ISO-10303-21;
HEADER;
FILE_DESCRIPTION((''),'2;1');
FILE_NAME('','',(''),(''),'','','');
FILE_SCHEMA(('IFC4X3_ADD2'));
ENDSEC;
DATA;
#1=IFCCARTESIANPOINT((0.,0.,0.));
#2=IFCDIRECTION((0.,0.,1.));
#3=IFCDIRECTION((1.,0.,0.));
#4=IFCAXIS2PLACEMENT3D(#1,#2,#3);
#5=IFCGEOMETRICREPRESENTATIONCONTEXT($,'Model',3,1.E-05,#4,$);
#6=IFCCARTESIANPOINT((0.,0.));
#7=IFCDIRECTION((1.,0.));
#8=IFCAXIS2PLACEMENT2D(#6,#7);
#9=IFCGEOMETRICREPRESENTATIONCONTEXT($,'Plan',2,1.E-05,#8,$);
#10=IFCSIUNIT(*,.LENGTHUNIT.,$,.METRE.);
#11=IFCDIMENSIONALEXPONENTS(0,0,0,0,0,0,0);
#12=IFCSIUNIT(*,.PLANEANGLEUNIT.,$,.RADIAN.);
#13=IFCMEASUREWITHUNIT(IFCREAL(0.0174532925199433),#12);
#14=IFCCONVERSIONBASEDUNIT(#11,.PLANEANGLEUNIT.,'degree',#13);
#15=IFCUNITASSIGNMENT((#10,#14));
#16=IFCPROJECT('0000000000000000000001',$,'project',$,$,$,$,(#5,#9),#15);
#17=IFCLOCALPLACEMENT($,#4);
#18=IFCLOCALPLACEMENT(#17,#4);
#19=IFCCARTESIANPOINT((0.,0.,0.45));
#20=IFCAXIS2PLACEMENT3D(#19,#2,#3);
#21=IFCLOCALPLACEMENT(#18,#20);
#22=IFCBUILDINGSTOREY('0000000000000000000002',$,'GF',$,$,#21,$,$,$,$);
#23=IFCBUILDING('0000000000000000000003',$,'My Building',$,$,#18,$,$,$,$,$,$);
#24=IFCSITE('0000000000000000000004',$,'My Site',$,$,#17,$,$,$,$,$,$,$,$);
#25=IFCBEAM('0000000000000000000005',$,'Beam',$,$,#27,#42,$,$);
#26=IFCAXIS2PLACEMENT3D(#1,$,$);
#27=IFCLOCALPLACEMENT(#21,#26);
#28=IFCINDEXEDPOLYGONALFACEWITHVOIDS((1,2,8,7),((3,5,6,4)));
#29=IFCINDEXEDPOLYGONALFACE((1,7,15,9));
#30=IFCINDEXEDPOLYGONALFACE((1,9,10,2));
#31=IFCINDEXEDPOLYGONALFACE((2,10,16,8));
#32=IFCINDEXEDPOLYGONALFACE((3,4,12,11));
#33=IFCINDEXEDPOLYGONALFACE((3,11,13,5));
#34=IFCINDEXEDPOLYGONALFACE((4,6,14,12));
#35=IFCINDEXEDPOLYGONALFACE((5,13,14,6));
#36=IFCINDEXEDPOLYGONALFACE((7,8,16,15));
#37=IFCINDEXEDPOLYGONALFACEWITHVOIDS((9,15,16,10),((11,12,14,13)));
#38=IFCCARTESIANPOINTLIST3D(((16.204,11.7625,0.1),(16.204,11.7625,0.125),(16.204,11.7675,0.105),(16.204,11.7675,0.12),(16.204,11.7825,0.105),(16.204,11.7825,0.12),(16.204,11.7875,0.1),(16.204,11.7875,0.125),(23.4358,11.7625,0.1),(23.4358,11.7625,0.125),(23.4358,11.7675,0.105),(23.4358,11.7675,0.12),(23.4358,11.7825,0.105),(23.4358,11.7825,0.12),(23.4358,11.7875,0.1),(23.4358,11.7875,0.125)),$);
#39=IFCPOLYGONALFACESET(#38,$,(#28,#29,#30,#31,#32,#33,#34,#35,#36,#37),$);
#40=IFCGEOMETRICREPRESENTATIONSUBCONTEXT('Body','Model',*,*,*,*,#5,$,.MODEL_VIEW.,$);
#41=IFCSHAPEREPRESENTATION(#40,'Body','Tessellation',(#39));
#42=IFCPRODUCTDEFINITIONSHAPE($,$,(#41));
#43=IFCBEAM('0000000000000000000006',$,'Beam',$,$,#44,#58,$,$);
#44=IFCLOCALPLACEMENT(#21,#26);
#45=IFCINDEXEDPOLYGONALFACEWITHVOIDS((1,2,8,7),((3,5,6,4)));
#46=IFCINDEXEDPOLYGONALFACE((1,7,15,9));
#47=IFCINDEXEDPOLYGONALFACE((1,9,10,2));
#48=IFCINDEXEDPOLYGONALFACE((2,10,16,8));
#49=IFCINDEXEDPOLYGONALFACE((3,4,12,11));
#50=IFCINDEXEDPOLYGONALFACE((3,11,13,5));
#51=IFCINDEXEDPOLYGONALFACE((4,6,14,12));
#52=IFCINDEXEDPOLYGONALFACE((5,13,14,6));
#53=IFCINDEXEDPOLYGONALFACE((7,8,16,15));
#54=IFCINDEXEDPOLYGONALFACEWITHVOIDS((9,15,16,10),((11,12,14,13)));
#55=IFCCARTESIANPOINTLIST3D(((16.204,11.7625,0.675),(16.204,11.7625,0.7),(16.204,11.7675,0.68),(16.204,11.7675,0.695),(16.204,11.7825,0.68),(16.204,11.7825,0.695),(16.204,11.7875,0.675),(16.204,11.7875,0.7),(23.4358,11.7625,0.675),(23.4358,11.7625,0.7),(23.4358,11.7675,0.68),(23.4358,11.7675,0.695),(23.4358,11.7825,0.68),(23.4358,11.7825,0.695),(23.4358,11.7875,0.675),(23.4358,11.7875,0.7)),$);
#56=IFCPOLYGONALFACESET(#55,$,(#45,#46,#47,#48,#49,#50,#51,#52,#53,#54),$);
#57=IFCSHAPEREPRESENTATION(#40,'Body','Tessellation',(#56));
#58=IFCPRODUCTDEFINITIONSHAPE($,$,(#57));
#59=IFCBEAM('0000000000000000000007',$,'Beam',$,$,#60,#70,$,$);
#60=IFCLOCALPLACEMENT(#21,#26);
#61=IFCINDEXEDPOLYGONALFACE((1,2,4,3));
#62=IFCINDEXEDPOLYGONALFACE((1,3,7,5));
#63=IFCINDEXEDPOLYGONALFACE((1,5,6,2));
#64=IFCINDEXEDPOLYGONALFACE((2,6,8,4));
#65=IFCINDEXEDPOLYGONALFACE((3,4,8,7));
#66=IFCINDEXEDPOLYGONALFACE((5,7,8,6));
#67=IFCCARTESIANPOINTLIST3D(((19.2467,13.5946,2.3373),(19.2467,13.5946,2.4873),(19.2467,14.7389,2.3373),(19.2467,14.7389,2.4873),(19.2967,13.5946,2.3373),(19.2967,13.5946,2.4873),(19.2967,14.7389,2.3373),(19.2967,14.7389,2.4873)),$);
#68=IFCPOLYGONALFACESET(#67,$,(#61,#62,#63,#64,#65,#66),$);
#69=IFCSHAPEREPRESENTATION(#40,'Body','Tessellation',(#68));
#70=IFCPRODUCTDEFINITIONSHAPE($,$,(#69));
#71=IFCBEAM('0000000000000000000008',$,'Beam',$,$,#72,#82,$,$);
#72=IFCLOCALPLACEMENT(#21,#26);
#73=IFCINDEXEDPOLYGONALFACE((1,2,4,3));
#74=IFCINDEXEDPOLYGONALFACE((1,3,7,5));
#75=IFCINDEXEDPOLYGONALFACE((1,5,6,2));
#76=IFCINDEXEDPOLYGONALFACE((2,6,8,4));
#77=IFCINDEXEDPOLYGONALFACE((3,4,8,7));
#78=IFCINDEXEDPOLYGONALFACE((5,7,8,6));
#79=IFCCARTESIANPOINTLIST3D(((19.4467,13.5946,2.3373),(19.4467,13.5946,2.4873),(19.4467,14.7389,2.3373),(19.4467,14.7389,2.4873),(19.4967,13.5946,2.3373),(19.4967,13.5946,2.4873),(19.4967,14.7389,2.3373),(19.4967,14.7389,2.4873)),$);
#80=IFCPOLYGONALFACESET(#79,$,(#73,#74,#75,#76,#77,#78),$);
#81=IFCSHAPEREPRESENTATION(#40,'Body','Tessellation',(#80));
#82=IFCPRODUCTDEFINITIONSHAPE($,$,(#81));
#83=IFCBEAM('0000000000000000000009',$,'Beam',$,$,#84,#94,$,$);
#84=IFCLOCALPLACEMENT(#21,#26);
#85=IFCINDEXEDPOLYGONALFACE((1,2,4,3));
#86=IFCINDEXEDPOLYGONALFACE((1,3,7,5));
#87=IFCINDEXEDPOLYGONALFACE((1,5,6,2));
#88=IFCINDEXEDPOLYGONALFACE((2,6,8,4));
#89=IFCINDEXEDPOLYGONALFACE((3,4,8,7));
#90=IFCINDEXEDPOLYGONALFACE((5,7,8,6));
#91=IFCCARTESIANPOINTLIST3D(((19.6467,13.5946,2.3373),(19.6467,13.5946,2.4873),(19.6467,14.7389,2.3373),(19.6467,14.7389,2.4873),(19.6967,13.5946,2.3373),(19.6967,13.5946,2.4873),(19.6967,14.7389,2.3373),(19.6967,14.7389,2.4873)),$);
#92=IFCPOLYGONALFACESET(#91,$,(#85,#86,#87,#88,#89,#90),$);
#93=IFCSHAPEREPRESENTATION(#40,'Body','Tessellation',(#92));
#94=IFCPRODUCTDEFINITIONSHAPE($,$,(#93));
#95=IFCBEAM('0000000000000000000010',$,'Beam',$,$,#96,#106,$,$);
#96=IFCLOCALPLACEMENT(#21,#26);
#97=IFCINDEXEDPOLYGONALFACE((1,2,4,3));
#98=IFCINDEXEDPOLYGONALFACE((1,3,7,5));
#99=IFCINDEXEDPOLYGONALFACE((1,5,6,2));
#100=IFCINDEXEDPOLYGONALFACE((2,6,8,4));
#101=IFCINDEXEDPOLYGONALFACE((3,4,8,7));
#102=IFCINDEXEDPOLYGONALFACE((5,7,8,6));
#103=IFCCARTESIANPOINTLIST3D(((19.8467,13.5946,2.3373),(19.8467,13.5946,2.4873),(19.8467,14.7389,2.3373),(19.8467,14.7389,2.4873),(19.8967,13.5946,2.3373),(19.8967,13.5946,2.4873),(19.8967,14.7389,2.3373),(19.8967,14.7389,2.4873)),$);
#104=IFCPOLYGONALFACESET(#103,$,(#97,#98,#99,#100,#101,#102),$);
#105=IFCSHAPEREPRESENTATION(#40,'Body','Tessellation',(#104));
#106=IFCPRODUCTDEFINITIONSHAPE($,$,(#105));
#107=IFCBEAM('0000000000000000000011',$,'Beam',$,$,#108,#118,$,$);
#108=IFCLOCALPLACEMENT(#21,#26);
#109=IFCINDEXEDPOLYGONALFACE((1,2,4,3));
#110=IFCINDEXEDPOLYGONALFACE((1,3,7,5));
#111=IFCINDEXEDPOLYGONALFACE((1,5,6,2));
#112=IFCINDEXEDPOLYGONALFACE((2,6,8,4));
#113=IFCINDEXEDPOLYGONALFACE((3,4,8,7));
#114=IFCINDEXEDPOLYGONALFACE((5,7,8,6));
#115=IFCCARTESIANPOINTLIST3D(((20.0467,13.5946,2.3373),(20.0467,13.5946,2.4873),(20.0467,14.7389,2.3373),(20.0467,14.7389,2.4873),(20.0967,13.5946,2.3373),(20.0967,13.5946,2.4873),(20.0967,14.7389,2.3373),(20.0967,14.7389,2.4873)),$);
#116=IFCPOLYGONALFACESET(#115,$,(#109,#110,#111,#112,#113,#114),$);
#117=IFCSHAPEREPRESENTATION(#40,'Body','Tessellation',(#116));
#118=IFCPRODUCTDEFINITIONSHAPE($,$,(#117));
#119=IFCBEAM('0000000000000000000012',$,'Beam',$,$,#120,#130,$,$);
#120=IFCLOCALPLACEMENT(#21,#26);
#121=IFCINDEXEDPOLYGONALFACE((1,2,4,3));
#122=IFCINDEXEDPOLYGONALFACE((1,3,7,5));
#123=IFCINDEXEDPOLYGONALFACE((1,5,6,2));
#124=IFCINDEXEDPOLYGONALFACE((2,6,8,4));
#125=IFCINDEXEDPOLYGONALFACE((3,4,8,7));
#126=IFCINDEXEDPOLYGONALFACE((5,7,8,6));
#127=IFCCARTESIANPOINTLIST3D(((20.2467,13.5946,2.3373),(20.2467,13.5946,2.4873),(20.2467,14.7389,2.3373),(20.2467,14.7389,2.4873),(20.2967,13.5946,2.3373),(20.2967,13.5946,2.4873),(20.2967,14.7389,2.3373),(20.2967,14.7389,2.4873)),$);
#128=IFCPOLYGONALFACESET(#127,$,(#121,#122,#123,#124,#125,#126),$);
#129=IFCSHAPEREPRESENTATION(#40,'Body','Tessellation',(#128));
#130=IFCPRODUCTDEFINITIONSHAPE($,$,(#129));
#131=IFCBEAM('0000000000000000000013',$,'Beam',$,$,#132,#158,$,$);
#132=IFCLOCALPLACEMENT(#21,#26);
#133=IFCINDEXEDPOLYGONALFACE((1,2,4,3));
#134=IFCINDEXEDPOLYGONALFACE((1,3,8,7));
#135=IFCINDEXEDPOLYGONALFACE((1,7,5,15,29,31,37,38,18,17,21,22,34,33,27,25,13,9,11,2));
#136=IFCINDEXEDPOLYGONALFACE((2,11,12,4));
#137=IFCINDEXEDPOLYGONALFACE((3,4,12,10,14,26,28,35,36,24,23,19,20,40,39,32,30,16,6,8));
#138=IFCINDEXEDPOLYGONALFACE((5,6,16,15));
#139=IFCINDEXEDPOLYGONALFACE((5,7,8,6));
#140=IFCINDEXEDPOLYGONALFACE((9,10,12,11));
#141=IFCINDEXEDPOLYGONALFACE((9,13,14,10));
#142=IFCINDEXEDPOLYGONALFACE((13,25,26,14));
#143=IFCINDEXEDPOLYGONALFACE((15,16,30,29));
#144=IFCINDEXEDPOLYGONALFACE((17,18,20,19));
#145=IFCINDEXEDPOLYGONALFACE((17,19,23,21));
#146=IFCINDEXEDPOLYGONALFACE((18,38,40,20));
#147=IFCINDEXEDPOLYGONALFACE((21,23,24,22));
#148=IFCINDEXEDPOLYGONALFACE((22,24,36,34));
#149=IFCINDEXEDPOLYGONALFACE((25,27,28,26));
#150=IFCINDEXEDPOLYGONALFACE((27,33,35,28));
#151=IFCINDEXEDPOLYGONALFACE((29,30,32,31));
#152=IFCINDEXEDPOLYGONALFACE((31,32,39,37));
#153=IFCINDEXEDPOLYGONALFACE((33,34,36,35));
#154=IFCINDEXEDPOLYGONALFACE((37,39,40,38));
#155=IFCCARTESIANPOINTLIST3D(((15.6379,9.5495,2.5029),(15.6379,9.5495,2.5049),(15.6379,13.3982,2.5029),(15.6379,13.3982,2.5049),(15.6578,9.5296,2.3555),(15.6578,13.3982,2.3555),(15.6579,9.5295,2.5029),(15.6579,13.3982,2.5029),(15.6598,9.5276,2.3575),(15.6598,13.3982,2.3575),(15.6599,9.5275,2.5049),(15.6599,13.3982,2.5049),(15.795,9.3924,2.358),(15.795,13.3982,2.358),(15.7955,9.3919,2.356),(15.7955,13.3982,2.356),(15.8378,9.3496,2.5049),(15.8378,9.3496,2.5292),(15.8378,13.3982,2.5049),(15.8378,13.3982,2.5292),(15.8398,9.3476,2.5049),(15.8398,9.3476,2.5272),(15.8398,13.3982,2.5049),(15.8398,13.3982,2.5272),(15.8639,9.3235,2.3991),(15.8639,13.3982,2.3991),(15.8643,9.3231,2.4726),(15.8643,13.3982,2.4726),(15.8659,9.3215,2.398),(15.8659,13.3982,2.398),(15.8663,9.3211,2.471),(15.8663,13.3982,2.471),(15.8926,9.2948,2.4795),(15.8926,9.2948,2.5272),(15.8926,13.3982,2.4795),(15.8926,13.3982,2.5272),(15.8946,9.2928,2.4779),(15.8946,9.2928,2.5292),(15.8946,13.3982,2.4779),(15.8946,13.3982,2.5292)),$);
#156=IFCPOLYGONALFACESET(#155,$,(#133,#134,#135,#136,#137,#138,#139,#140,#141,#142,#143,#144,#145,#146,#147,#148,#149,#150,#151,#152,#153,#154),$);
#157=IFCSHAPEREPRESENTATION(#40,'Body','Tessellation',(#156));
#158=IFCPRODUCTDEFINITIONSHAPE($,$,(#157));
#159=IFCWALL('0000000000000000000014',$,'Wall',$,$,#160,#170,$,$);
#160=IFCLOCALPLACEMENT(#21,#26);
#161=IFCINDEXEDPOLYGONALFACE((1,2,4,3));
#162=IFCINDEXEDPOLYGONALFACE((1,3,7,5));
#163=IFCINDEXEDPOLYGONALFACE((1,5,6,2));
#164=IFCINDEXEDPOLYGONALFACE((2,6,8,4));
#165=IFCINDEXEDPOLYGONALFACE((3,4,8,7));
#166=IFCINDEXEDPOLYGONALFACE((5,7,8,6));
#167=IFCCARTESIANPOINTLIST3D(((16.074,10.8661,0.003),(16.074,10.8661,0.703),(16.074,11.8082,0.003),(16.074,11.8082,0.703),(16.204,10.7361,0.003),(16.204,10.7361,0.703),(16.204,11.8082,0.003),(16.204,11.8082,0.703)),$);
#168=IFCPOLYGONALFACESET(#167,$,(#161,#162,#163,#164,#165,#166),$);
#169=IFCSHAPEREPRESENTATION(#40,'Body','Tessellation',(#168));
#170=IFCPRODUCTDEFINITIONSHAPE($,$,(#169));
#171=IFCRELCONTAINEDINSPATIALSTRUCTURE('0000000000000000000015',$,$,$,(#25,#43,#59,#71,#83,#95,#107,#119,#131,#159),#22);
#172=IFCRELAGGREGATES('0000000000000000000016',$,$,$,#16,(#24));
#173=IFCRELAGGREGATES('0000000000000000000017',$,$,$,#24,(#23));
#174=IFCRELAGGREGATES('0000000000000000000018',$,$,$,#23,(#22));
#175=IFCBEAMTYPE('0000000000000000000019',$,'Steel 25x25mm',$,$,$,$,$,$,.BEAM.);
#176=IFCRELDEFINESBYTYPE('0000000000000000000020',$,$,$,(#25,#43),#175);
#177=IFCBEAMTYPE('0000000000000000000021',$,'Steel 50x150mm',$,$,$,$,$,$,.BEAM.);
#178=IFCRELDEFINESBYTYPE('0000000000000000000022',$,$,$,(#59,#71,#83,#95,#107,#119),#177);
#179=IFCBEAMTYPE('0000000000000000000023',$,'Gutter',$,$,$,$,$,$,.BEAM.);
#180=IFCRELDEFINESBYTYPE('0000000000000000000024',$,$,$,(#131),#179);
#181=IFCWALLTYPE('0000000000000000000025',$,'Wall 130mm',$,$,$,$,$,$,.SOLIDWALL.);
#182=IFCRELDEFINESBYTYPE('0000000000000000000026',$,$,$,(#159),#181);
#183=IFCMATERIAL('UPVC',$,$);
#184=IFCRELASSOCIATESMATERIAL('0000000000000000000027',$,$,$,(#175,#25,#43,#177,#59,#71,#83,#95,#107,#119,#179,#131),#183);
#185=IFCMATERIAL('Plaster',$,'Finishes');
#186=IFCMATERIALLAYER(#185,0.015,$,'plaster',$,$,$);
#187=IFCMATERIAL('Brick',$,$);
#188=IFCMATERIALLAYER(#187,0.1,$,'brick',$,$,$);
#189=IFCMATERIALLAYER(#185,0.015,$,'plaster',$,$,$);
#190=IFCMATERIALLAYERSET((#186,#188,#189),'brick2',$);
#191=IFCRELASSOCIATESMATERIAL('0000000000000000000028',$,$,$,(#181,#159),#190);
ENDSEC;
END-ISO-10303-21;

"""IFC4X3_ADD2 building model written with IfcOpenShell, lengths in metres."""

from ifc_helpers import new_model, entity, si_unit, converted_unit, frame, origin_with_axes, origin_2d_with_axis, place, context, subcontext, project, spatial, line, indexed_curve, rectangle, hollow_rectangle, outline, extrude, clip, halfspace, material, layer, layer_set, layer_usage, material_profile, profile_set, profile_usage, type_object, element, save


model = new_model("IFC4X3_ADD2")

# Units and contexts
model_context = context("Model", 3, precision=1e-05, world=origin_with_axes())
plan_context = context("Plan", 2, precision=1e-05, world=origin_2d_with_axis())
body_context = subcontext(model_context, "Body", "Model", "MODEL_VIEW")
ifc_project = project(units=[si_unit("LENGTHUNIT", "METRE"), converted_unit("PLANEANGLEUNIT", "degree", entity("IfcReal", 0.0174532925199433), si_unit("PLANEANGLEUNIT", "RADIAN"), dimensions=[0, 0, 0, 0, 0, 0, 0])], contexts=[model_context, plan_context])

# Site, building, storey
site_placement = place(None, origin_with_axes())
site = spatial("IfcSite", under=ifc_project, at=site_placement, Name="My Site")
building_placement = place(site_placement, origin_with_axes())
building = spatial("IfcBuilding", under=site, at=building_placement, Name="My Building")
storey_placement = place(building_placement, frame((0.0, 0.0, 0.45), z_axis=(0.0, 0.0, 1.0), x_axis=(1.0, 0.0, 0.0)))
storey = spatial("IfcBuildingStorey", under=building, at=storey_placement, Name="GF")

# Shared definitions
ifc_material_1 = material(Name="UPVC")

# Beams
ifc_material_profile_1 = material_profile(ifc_material_1, hollow_rectangle(XDim=0.025, YDim=0.025, WallThickness=0.005))
ifc_profile_set_1 = profile_set([ifc_material_profile_1])
ifc_profile_usage_1 = profile_usage(ifc_profile_set_1)
beam_type_1 = type_object("IfcBeamType", Name="Steel 25x25mm", PredefinedType="BEAM", material=ifc_profile_set_1)
beam_1_placement = place(storey_placement, frame((16.204, 11.775, 0.1125), z_axis=(1.0, 0.0, 0.0), x_axis=(0.0, 1.0, 0.0)))
element("IfcBeam", 1, at=beam_1_placement, inside=storey, type_object=beam_type_1, material=ifc_profile_usage_1, Name="Beam", context=body_context, shape_type="SweptSolid", body=[
    extrude(hollow_rectangle(XDim=0.025, YDim=0.025, WallThickness=0.005), origin_with_axes(), (0.0, 0.0, 1.0), 7.2317),
])
ifc_profile_usage_2 = profile_usage(ifc_profile_set_1)
beam_2_placement = place(storey_placement, frame((16.204, 11.775, 0.6875), z_axis=(1.0, 0.0, 0.0), x_axis=(0.0, 1.0, 0.0)))
element("IfcBeam", 2, at=beam_2_placement, inside=storey, type_object=beam_type_1, material=ifc_profile_usage_2, Name="Beam", context=body_context, shape_type="SweptSolid", body=[
    extrude(hollow_rectangle(XDim=0.025, YDim=0.025, WallThickness=0.005), origin_with_axes(), (0.0, 0.0, 1.0), 7.2317),
])
ifc_material_profile_2 = material_profile(ifc_material_1, rectangle(XDim=0.05, YDim=0.15))
ifc_profile_set_2 = profile_set([ifc_material_profile_2])
ifc_profile_usage_3 = profile_usage(ifc_profile_set_2)
beam_type_2 = type_object("IfcBeamType", Name="Steel 50x150mm", PredefinedType="BEAM", material=ifc_profile_set_2)
beam_3_placement = place(storey_placement, frame((19.2717, 14.7389, 2.4123), z_axis=(0.0, -1.0, 0.0), x_axis=(1.0, 0.0, 0.0)))
element("IfcBeam", 3, at=beam_3_placement, inside=storey, type_object=beam_type_2, material=ifc_profile_usage_3, Name="Beam", context=body_context, shape_type="SweptSolid", body=[
    extrude(rectangle(XDim=0.05, YDim=0.15), origin_with_axes(), (0.0, 0.0, 1.0), 1.1444),
])
ifc_profile_usage_4 = profile_usage(ifc_profile_set_2)
beam_4_placement = place(storey_placement, frame((19.4717, 14.7389, 2.4123), z_axis=(0.0, -1.0, 0.0), x_axis=(1.0, 0.0, 0.0)))
element("IfcBeam", 4, at=beam_4_placement, inside=storey, type_object=beam_type_2, material=ifc_profile_usage_4, Name="Beam", context=body_context, shape_type="SweptSolid", body=[
    extrude(rectangle(XDim=0.05, YDim=0.15), origin_with_axes(), (0.0, 0.0, 1.0), 1.1444),
])
ifc_profile_usage_5 = profile_usage(ifc_profile_set_2)
beam_5_placement = place(storey_placement, frame((19.6717, 14.7389, 2.4123), z_axis=(0.0, -1.0, 0.0), x_axis=(1.0, 0.0, 0.0)))
element("IfcBeam", 5, at=beam_5_placement, inside=storey, type_object=beam_type_2, material=ifc_profile_usage_5, Name="Beam", context=body_context, shape_type="SweptSolid", body=[
    extrude(rectangle(XDim=0.05, YDim=0.15), origin_with_axes(), (0.0, 0.0, 1.0), 1.1444),
])
ifc_profile_usage_6 = profile_usage(ifc_profile_set_2)
beam_6_placement = place(storey_placement, frame((19.8717, 14.7389, 2.4123), z_axis=(0.0, -1.0, 0.0), x_axis=(1.0, 0.0, 0.0)))
element("IfcBeam", 6, at=beam_6_placement, inside=storey, type_object=beam_type_2, material=ifc_profile_usage_6, Name="Beam", context=body_context, shape_type="SweptSolid", body=[
    extrude(rectangle(XDim=0.05, YDim=0.15), origin_with_axes(), (0.0, 0.0, 1.0), 1.1444),
])
ifc_profile_usage_7 = profile_usage(ifc_profile_set_2)
beam_7_placement = place(storey_placement, frame((20.0717, 14.7389, 2.4123), z_axis=(0.0, -1.0, 0.0), x_axis=(1.0, 0.0, 0.0)))
element("IfcBeam", 7, at=beam_7_placement, inside=storey, type_object=beam_type_2, material=ifc_profile_usage_7, Name="Beam", context=body_context, shape_type="SweptSolid", body=[
    extrude(rectangle(XDim=0.05, YDim=0.15), origin_with_axes(), (0.0, 0.0, 1.0), 1.1444),
])
ifc_profile_usage_8 = profile_usage(ifc_profile_set_2)
beam_8_placement = place(storey_placement, frame((20.2717, 14.7389, 2.4123), z_axis=(0.0, -1.0, 0.0), x_axis=(1.0, 0.0, 0.0)))
element("IfcBeam", 8, at=beam_8_placement, inside=storey, type_object=beam_type_2, material=ifc_profile_usage_8, Name="Beam", context=body_context, shape_type="SweptSolid", body=[
    extrude(rectangle(XDim=0.05, YDim=0.15), origin_with_axes(), (0.0, 0.0, 1.0), 1.1444),
])
ifc_material_profile_3 = material_profile(ifc_material_1, outline(indexed_curve([(0.0548, 0.1717), (0.002, 0.1717), (0.002, 0.124), (0.0303, 0.1171), (0.0307, 0.0436), (0.0996, 0.0025), (0.2349, 0.002), (0.2347, 0.1494), (0.2567, 0.1494), (0.2567, 0.1474), (0.2367, 0.1474), (0.2369, 0.0), (0.0991, 0.0005), (0.0287, 0.0425), (0.0283, 0.1155), (0.0, 0.1224), (0.0, 0.1737), (0.0568, 0.1737), (0.0568, 0.1494), (0.0548, 0.1494), (0.0548, 0.1717)])))
ifc_profile_set_3 = profile_set([ifc_material_profile_3])
ifc_profile_usage_9 = profile_usage(ifc_profile_set_3, cardinal=5)
beam_type_3 = type_object("IfcBeamType", Name="Gutter", PredefinedType="BEAM", material=ifc_profile_set_3)
beam_9_placement = place(storey_placement, frame((15.8946, 9.2928, 2.3555), z_axis=(0.0, 1.0, 0.0), x_axis=(-1.0, 0.0, 0.0)))
element("IfcBeam", 9, at=beam_9_placement, inside=storey, type_object=beam_type_3, material=ifc_profile_usage_9, Name="Beam", context=body_context, shape_type="Clipping", body=[
    clip(extrude(outline(indexed_curve([(0.0548, 0.1717), (0.002, 0.1717), (0.002, 0.124), (0.0303, 0.1171), (0.0307, 0.0436), (0.0996, 0.0025), (0.2349, 0.002), (0.2347, 0.1494), (0.2567, 0.1494), (0.2567, 0.1474), (0.2367, 0.1474), (0.2369, 0.0), (0.0991, 0.0005), (0.0287, 0.0425), (0.0283, 0.1155), (0.0, 0.1224), (0.0, 0.1737), (0.0568, 0.1737), (0.0568, 0.1494), (0.0548, 0.1494), (0.0548, 0.1717)])), origin_with_axes(), (0.0, 0.0, 1.0), 4.1054), halfspace(frame((0.0, -2.6573, 0.0), z_axis=(0.707108, 0.0, -0.707106), x_axis=(0.0, -1.0, 0.0)), False)),
])

# Wall
ifc_material_2 = material(Name="Plaster", Category="Finishes")
ifc_layer_1 = layer(ifc_material_2, 0.015, Name="plaster")
ifc_material_3 = material(Name="Brick")
ifc_layer_2 = layer(ifc_material_3, 0.1, Name="brick")
ifc_layer_3 = layer(ifc_material_2, 0.015, Name="plaster")
ifc_layer_set = layer_set([ifc_layer_1, ifc_layer_2, ifc_layer_3], Name="brick2")
ifc_layer_usage = layer_usage(ifc_layer_set, "AXIS2", "POSITIVE", 0.0)
wall_type = type_object("IfcWallType", Name="Wall 130mm", PredefinedType="SOLIDWALL", material=ifc_layer_set)
wall_placement = place(storey_placement, frame((16.204, 10.7361, 0.003), z_axis=(0.0, 0.0, 1.0), x_axis=(0.0, 1.0, 0.0)))
element("IfcWall", 10, at=wall_placement, inside=storey, type_object=wall_type, material=ifc_layer_usage, Name="Wall", context=body_context, shape_type="SweptSolid", body=[
    extrude(outline(indexed_curve([(0.0, 0.0), (0.13, 0.13), (1.072, 0.13), (1.072, 0.0)], segments=[line(1, 2, 3, 4, 1)])), origin_with_axes(), (0.0, 0.0, 1.0), 0.7),
])

save(model, "model.ifc")
